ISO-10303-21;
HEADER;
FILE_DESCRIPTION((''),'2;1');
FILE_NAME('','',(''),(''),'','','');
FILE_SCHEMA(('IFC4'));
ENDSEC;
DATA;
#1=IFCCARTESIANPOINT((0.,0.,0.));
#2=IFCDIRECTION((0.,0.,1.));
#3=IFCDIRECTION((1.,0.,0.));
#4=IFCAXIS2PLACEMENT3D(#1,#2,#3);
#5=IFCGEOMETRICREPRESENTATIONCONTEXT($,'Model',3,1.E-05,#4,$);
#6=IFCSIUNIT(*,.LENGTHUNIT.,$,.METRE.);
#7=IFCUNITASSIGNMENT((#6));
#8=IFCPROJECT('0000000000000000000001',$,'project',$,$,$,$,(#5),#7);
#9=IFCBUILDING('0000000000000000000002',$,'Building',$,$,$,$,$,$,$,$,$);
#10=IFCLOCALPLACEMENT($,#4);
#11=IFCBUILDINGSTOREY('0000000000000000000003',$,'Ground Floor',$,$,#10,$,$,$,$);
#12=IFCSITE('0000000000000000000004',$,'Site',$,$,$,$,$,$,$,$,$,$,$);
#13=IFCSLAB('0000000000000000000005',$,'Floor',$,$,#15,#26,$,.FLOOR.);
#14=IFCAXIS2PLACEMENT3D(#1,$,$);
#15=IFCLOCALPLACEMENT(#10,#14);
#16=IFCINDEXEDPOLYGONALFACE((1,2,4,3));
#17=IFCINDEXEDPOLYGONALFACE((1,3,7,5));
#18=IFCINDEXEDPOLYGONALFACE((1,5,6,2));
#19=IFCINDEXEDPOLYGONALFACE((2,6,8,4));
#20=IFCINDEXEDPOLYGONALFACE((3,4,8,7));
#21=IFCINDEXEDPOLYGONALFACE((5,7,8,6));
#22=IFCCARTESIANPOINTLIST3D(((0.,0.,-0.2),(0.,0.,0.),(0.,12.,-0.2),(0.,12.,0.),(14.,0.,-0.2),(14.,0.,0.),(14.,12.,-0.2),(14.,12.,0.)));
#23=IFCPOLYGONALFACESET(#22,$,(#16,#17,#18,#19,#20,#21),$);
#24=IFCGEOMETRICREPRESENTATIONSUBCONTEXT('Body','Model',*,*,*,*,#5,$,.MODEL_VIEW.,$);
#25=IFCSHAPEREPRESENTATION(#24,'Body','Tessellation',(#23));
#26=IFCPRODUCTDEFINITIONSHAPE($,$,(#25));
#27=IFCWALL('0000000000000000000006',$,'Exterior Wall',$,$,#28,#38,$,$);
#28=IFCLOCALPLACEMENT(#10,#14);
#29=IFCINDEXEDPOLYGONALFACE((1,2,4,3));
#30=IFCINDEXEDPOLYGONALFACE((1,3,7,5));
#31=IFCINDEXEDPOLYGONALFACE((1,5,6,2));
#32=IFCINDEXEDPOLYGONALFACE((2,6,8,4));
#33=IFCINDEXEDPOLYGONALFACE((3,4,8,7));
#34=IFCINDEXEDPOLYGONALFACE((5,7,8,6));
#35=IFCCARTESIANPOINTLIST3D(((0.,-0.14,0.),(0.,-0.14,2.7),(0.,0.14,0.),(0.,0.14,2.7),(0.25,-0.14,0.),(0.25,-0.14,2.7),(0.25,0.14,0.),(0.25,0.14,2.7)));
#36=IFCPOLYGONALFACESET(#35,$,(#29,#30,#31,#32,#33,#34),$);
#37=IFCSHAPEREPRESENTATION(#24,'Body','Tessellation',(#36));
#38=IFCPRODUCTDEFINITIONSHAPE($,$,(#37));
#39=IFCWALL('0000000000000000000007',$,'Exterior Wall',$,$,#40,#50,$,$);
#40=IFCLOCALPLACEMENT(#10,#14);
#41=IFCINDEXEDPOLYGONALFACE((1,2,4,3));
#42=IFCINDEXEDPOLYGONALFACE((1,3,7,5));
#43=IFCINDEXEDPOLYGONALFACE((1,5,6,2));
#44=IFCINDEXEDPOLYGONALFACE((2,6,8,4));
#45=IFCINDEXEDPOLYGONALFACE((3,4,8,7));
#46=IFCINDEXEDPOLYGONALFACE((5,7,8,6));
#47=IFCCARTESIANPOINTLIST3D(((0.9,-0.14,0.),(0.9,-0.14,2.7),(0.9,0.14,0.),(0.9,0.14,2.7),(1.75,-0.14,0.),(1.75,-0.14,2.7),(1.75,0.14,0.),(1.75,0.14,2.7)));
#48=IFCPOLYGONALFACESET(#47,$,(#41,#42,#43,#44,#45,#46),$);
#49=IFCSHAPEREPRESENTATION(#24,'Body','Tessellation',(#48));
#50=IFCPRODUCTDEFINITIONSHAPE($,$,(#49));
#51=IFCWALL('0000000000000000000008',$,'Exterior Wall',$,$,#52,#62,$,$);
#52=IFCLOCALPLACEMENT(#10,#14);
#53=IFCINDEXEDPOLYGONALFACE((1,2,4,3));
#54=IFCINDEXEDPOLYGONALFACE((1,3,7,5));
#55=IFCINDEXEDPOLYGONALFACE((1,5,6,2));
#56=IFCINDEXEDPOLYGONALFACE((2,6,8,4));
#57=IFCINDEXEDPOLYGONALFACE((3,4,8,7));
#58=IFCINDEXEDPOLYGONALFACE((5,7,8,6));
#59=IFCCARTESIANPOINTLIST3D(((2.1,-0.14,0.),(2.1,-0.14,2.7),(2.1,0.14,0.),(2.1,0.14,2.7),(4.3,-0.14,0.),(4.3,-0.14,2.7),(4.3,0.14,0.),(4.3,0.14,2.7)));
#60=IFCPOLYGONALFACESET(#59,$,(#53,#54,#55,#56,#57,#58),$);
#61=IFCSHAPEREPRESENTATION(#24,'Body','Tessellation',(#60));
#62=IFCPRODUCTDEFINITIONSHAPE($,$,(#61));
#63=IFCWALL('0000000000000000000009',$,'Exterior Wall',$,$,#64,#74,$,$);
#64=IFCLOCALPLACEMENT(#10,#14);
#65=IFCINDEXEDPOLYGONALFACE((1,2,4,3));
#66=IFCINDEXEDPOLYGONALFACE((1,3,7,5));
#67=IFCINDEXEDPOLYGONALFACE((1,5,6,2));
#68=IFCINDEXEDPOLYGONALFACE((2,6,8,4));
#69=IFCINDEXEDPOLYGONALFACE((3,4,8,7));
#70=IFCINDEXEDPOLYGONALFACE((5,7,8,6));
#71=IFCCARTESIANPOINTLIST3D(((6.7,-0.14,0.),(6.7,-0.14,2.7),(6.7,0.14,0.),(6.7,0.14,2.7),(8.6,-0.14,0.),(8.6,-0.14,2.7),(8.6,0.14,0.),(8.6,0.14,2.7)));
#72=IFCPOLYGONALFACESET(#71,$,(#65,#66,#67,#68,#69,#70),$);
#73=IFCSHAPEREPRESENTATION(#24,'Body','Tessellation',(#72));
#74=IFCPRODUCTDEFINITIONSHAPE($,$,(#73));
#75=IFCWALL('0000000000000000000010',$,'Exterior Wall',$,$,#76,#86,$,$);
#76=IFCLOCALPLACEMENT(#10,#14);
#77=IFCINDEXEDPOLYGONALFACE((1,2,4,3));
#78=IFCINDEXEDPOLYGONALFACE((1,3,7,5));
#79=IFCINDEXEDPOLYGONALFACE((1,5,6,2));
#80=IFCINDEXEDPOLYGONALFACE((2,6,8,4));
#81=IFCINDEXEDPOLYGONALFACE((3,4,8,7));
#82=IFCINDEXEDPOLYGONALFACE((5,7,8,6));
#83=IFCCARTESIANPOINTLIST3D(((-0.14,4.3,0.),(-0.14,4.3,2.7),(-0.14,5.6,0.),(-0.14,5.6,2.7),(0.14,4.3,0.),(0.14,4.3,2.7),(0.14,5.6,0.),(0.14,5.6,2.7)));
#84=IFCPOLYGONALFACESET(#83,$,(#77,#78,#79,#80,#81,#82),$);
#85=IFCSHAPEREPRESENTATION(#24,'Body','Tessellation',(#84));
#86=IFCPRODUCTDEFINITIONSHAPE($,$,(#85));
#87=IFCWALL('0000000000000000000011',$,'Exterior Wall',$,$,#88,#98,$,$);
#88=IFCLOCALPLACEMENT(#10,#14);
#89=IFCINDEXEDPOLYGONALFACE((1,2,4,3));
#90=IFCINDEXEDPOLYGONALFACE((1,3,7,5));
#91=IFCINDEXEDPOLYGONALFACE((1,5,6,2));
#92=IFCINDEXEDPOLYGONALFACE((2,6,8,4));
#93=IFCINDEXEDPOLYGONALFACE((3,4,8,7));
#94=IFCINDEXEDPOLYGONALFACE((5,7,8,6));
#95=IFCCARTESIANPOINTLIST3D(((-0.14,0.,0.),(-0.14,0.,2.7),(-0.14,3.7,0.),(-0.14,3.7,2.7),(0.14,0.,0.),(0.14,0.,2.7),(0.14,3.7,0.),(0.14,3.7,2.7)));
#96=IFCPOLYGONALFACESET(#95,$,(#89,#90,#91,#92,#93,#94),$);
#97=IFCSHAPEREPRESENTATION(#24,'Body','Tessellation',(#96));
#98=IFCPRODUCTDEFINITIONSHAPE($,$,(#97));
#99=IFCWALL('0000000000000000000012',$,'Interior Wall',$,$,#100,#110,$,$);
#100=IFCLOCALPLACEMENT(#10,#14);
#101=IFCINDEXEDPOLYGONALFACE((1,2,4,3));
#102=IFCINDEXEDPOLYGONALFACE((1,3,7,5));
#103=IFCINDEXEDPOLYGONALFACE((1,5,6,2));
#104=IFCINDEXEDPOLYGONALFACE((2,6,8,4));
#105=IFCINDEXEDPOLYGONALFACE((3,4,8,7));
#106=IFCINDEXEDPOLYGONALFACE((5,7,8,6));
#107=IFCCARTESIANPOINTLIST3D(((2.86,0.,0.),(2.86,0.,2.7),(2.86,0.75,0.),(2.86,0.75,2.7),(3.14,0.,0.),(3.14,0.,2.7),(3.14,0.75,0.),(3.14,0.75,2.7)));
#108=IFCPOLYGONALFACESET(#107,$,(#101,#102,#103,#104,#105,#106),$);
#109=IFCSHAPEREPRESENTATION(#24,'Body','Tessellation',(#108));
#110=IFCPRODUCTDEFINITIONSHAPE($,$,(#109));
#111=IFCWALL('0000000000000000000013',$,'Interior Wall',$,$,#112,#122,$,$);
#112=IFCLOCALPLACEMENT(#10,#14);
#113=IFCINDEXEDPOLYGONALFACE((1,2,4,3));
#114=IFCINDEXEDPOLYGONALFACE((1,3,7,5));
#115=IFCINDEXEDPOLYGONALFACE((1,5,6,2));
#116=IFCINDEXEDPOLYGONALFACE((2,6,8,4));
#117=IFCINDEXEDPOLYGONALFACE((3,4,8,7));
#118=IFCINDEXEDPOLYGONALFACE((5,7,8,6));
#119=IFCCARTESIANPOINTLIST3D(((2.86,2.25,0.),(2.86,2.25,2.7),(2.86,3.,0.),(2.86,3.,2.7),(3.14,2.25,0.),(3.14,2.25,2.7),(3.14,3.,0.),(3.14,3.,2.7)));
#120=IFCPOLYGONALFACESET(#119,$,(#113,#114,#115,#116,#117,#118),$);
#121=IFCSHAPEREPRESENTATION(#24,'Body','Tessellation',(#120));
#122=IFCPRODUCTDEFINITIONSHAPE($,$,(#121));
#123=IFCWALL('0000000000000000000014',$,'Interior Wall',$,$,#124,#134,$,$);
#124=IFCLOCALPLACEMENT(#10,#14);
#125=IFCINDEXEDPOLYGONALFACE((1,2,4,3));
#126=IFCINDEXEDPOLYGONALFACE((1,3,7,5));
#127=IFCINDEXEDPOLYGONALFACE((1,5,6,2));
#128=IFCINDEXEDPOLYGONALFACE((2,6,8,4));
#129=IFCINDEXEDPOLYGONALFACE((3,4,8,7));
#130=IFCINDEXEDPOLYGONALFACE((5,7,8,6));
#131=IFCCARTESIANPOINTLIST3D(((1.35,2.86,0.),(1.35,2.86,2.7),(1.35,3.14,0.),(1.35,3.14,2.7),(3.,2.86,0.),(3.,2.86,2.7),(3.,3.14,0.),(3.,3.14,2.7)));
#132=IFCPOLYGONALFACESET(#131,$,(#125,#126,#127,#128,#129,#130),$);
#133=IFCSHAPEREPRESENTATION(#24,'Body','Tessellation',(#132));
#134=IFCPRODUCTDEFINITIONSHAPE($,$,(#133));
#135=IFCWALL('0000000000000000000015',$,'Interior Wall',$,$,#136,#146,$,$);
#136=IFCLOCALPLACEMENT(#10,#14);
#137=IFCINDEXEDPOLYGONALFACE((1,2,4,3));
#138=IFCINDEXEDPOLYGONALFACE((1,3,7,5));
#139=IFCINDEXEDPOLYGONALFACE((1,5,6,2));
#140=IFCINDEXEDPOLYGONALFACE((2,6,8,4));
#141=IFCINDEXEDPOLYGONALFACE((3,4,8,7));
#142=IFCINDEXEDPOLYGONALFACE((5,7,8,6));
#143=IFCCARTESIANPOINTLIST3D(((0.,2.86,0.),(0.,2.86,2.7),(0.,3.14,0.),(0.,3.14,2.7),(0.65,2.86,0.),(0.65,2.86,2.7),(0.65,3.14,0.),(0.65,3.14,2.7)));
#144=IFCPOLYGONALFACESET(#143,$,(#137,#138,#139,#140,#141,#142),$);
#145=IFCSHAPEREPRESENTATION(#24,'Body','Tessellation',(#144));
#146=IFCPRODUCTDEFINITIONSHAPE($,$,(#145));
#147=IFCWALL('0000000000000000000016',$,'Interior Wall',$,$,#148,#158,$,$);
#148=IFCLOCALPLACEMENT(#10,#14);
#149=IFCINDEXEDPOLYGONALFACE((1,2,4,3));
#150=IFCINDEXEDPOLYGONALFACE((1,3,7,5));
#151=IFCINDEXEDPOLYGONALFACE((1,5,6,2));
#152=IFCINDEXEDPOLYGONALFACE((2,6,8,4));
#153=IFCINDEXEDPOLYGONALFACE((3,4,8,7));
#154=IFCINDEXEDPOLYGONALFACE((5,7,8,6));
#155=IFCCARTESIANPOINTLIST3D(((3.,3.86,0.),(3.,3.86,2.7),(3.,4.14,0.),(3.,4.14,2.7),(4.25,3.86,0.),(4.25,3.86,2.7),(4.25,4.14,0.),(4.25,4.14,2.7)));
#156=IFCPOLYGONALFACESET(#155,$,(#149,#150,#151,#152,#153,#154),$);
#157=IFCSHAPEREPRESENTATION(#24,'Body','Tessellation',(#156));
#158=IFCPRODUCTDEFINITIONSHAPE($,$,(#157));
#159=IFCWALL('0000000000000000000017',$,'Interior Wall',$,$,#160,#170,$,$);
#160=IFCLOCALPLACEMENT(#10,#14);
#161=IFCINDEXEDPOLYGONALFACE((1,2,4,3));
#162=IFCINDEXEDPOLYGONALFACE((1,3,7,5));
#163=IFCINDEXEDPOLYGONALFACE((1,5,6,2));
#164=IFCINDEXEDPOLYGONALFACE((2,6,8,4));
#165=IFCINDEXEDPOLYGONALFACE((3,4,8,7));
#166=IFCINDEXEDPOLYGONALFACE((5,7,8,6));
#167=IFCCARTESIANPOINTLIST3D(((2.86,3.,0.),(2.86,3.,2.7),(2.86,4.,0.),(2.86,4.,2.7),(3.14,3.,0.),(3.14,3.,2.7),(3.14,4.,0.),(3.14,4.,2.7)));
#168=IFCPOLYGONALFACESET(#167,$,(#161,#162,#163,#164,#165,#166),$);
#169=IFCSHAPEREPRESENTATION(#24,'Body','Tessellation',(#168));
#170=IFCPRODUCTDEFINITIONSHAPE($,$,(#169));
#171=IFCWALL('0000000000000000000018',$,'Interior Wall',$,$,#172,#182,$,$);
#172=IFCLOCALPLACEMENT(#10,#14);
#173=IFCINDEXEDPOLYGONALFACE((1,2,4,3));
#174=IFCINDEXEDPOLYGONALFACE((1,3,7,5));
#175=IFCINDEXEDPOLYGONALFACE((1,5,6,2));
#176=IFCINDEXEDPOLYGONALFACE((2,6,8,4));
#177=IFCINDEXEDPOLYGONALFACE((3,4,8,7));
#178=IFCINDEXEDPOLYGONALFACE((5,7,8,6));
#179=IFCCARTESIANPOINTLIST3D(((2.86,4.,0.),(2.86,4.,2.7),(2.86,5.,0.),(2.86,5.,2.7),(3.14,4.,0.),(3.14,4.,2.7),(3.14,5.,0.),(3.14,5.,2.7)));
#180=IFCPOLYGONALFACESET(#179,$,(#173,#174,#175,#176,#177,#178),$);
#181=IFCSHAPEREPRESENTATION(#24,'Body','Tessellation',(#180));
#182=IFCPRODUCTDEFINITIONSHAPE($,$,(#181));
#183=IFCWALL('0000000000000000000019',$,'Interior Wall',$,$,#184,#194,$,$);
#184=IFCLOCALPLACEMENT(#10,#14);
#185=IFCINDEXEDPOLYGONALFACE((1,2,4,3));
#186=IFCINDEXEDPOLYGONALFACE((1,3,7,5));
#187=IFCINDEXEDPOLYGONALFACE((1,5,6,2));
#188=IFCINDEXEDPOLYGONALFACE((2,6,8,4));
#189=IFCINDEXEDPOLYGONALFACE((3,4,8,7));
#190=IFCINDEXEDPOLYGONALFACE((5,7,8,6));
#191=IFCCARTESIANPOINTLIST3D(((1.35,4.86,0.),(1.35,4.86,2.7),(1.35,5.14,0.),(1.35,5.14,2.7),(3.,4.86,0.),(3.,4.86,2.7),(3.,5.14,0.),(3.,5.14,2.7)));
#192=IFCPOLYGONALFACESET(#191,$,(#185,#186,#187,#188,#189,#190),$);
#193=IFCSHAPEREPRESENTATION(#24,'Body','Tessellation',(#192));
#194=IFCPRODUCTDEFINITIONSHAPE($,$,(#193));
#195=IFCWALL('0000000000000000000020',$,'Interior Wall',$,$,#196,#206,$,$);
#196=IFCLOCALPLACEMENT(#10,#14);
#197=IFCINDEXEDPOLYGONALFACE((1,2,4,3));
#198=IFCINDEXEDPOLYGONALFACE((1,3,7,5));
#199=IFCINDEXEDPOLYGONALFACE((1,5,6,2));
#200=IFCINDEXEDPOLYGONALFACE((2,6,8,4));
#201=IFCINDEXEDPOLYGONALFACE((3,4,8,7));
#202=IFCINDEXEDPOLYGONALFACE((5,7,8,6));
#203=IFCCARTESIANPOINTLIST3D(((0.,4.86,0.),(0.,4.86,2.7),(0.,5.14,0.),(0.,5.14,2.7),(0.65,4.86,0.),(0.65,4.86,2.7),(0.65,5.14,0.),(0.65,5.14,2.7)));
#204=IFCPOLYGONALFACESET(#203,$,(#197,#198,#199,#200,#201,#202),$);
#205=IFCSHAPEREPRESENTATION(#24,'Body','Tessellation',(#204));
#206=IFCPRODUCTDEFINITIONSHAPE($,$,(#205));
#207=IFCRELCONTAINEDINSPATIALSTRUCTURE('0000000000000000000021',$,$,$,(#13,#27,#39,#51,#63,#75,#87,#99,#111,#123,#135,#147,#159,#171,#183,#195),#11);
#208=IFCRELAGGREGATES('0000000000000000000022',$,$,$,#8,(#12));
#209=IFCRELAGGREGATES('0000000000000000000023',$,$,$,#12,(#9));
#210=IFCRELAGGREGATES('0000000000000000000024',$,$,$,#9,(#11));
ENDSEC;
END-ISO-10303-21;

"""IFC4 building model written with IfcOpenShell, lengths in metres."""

from ifc_helpers import new_model, si_unit, frame, origin_with_axes, place, context, subcontext, project, spatial, indexed_curve, outline, extrude, element, save


model = new_model("IFC4")

# Units and contexts
model_context = context("Model", 3, precision=1e-05, world=origin_with_axes())
body_context = subcontext(model_context, "Body", "Model", "MODEL_VIEW")
ifc_project = project(units=[si_unit("LENGTHUNIT", "METRE")], contexts=[model_context])

# Site, building, storey
site = spatial("IfcSite", under=ifc_project, Name="Site")
building = spatial("IfcBuilding", under=site, Name="Building")
storey_placement = place(None, origin_with_axes())
storey = spatial("IfcBuildingStorey", under=building, at=storey_placement, Name="Ground Floor")

# Slab
slab_placement = place(storey_placement, frame((0.0, 0.0, -0.2), z_axis=(0.0, 0.0, 1.0), x_axis=(1.0, 0.0, 0.0)))
element("IfcSlab", 1, at=slab_placement, inside=storey, Name="Floor", PredefinedType="FLOOR", context=body_context, shape_type="SweptSolid", body=[
    extrude(outline(indexed_curve([(0.0, 0.0), (14.0, 0.0), (14.0, 12.0), (0.0, 12.0)])), None, (0.0, 0.0, 1.0), 0.2),
])

# Walls
wall_1_placement = place(storey_placement, origin_with_axes())
element("IfcWall", 2, at=wall_1_placement, inside=storey, Name="Exterior Wall", context=body_context, shape_type="SweptSolid", body=[
    extrude(outline(indexed_curve([(0.0, 0.0), (0.0, 0.28), (0.25, 0.28), (0.25, 0.0), (0.0, 0.0)], self_intersect=False)), frame((0.0, -0.14, 0.0), z_axis=(0.0, 0.0, 1.0), x_axis=(1.0, 0.0, 0.0)), (0.0, 0.0, 1.0), 2.7),
])
wall_2_placement = place(storey_placement, frame((1.75, 0.0, 0.0), z_axis=(0.0, 0.0, 1.0), x_axis=(-1.0, 0.0, 0.0)))
element("IfcWall", 3, at=wall_2_placement, inside=storey, Name="Exterior Wall", context=body_context, shape_type="SweptSolid", body=[
    extrude(outline(indexed_curve([(0.0, 0.0), (0.0, 0.28), (0.85, 0.28), (0.85, 0.0), (0.0, 0.0)], self_intersect=False)), frame((0.0, -0.14, 0.0), z_axis=(0.0, 0.0, 1.0), x_axis=(1.0, 0.0, 0.0)), (0.0, 0.0, 1.0), 2.7),
])
wall_3_placement = place(storey_placement, frame((2.1, 0.0, 0.0), z_axis=(0.0, 0.0, 1.0), x_axis=(1.0, 0.0, 0.0)))
element("IfcWall", 4, at=wall_3_placement, inside=storey, Name="Exterior Wall", context=body_context, shape_type="SweptSolid", body=[
    extrude(outline(indexed_curve([(0.0, 0.0), (0.0, 0.28), (2.2, 0.28), (2.2, 0.0), (0.0, 0.0)], self_intersect=False)), frame((0.0, -0.14, 0.0), z_axis=(0.0, 0.0, 1.0), x_axis=(1.0, 0.0, 0.0)), (0.0, 0.0, 1.0), 2.7),
])
wall_4_placement = place(storey_placement, frame((6.7, 0.0, 0.0), z_axis=(0.0, 0.0, 1.0), x_axis=(1.0, 0.0, 0.0)))
element("IfcWall", 5, at=wall_4_placement, inside=storey, Name="Exterior Wall", context=body_context, shape_type="SweptSolid", body=[
    extrude(outline(indexed_curve([(0.0, 0.0), (0.0, 0.28), (1.9, 0.28), (1.9, 0.0), (0.0, 0.0)], self_intersect=False)), frame((0.0, -0.14, 0.0), z_axis=(0.0, 0.0, 1.0), x_axis=(1.0, 0.0, 0.0)), (0.0, 0.0, 1.0), 2.7),
])
wall_5_placement = place(storey_placement, frame((0.0, 5.6, 0.0), z_axis=(0.0, 0.0, 1.0), x_axis=(0.0, -1.0, 0.0)))
element("IfcWall", 6, at=wall_5_placement, inside=storey, Name="Exterior Wall", context=body_context, shape_type="SweptSolid", body=[
    extrude(outline(indexed_curve([(0.0, 0.0), (0.0, 0.28), (1.3, 0.28), (1.3, 0.0), (0.0, 0.0)], self_intersect=False)), frame((0.0, -0.14, 0.0), z_axis=(0.0, 0.0, 1.0), x_axis=(1.0, 0.0, 0.0)), (0.0, 0.0, 1.0), 2.7),
])
wall_6_placement = place(storey_placement, frame((0.0, 3.7, 0.0), z_axis=(0.0, 0.0, 1.0), x_axis=(0.0, -1.0, 0.0)))
element("IfcWall", 7, at=wall_6_placement, inside=storey, Name="Exterior Wall", context=body_context, shape_type="SweptSolid", body=[
    extrude(outline(indexed_curve([(0.0, 0.0), (0.0, 0.28), (3.7, 0.28), (3.7, 0.0), (0.0, 0.0)], self_intersect=False)), frame((0.0, -0.14, 0.0), z_axis=(0.0, 0.0, 1.0), x_axis=(1.0, 0.0, 0.0)), (0.0, 0.0, 1.0), 2.7),
])
for number, where, z_axis, x_axis, name in (
    (8, (3.0, 0.0, 0.0), (0.0, 0.0, 1.0), (0.0, 1.0, 0.0), "Interior Wall"),
    (9, (3.0, 2.25, 0.0), (0.0, 0.0, 1.0), (0.0, 1.0, 0.0), "Interior Wall"),
):
    element("IfcWall", number, at=place(storey_placement, frame(where, z_axis=z_axis, x_axis=x_axis)), inside=storey, Name=name, context=body_context, shape_type="SweptSolid", body=[
        extrude(outline(indexed_curve([(0.0, 0.0), (0.0, 0.28), (0.75, 0.28), (0.75, 0.0), (0.0, 0.0)], self_intersect=False)), frame((0.0, -0.14, 0.0), z_axis=(0.0, 0.0, 1.0), x_axis=(1.0, 0.0, 0.0)), (0.0, 0.0, 1.0), 2.7),
    ])
wall_7_placement = place(storey_placement, frame((3.0, 3.0, 0.0), z_axis=(0.0, 0.0, 1.0), x_axis=(-1.0, 0.0, 0.0)))
element("IfcWall", 10, at=wall_7_placement, inside=storey, Name="Interior Wall", context=body_context, shape_type="SweptSolid", body=[
    extrude(outline(indexed_curve([(0.0, 0.0), (0.0, 0.28), (1.65, 0.28), (1.65, 0.0), (0.0, 0.0)], self_intersect=False)), frame((0.0, -0.14, 0.0), z_axis=(0.0, 0.0, 1.0), x_axis=(1.0, 0.0, 0.0)), (0.0, 0.0, 1.0), 2.7),
])
wall_8_placement = place(storey_placement, frame((0.65, 3.0, 0.0), z_axis=(0.0, 0.0, 1.0), x_axis=(-1.0, 0.0, 0.0)))
element("IfcWall", 11, at=wall_8_placement, inside=storey, Name="Interior Wall", context=body_context, shape_type="SweptSolid", body=[
    extrude(outline(indexed_curve([(0.0, 0.0), (0.0, 0.28), (0.65, 0.28), (0.65, 0.0), (0.0, 0.0)], self_intersect=False)), frame((0.0, -0.14, 0.0), z_axis=(0.0, 0.0, 1.0), x_axis=(1.0, 0.0, 0.0)), (0.0, 0.0, 1.0), 2.7),
])
wall_9_placement = place(storey_placement, frame((4.25, 4.0, 0.0), z_axis=(0.0, 0.0, 1.0), x_axis=(-1.0, 0.0, 0.0)))
element("IfcWall", 12, at=wall_9_placement, inside=storey, Name="Interior Wall", context=body_context, shape_type="SweptSolid", body=[
    extrude(outline(indexed_curve([(0.0, 0.0), (0.0, 0.28), (1.25, 0.28), (1.25, 0.0), (0.0, 0.0)], self_intersect=False)), frame((0.0, -0.14, 0.0), z_axis=(0.0, 0.0, 1.0), x_axis=(1.0, 0.0, 0.0)), (0.0, 0.0, 1.0), 2.7),
])
for number, where, z_axis, x_axis, name in (
    (13, (3.0, 4.0, 0.0), (0.0, 0.0, 1.0), (0.0, -1.0, 0.0), "Interior Wall"),
    (14, (3.0, 4.0, 0.0), (0.0, 0.0, 1.0), (0.0, 1.0, 0.0), "Interior Wall"),
):
    element("IfcWall", number, at=place(storey_placement, frame(where, z_axis=z_axis, x_axis=x_axis)), inside=storey, Name=name, context=body_context, shape_type="SweptSolid", body=[
        extrude(outline(indexed_curve([(0.0, 0.0), (0.0, 0.28), (1.0, 0.28), (1.0, 0.0), (0.0, 0.0)], self_intersect=False)), frame((0.0, -0.14, 0.0), z_axis=(0.0, 0.0, 1.0), x_axis=(1.0, 0.0, 0.0)), (0.0, 0.0, 1.0), 2.7),
    ])
wall_10_placement = place(storey_placement, frame((3.0, 5.0, 0.0), z_axis=(0.0, 0.0, 1.0), x_axis=(-1.0, 0.0, 0.0)))
element("IfcWall", 15, at=wall_10_placement, inside=storey, Name="Interior Wall", context=body_context, shape_type="SweptSolid", body=[
    extrude(outline(indexed_curve([(0.0, 0.0), (0.0, 0.28), (1.65, 0.28), (1.65, 0.0), (0.0, 0.0)], self_intersect=False)), frame((0.0, -0.14, 0.0), z_axis=(0.0, 0.0, 1.0), x_axis=(1.0, 0.0, 0.0)), (0.0, 0.0, 1.0), 2.7),
])
wall_11_placement = place(storey_placement, frame((0.65, 5.0, 0.0), z_axis=(0.0, 0.0, 1.0), x_axis=(-1.0, 0.0, 0.0)))
element("IfcWall", 16, at=wall_11_placement, inside=storey, Name="Interior Wall", context=body_context, shape_type="SweptSolid", body=[
    extrude(outline(indexed_curve([(0.0, 0.0), (0.0, 0.28), (0.65, 0.28), (0.65, 0.0), (0.0, 0.0)], self_intersect=False)), frame((0.0, -0.14, 0.0), z_axis=(0.0, 0.0, 1.0), x_axis=(1.0, 0.0, 0.0)), (0.0, 0.0, 1.0), 2.7),
])

save(model, "model.ifc")
